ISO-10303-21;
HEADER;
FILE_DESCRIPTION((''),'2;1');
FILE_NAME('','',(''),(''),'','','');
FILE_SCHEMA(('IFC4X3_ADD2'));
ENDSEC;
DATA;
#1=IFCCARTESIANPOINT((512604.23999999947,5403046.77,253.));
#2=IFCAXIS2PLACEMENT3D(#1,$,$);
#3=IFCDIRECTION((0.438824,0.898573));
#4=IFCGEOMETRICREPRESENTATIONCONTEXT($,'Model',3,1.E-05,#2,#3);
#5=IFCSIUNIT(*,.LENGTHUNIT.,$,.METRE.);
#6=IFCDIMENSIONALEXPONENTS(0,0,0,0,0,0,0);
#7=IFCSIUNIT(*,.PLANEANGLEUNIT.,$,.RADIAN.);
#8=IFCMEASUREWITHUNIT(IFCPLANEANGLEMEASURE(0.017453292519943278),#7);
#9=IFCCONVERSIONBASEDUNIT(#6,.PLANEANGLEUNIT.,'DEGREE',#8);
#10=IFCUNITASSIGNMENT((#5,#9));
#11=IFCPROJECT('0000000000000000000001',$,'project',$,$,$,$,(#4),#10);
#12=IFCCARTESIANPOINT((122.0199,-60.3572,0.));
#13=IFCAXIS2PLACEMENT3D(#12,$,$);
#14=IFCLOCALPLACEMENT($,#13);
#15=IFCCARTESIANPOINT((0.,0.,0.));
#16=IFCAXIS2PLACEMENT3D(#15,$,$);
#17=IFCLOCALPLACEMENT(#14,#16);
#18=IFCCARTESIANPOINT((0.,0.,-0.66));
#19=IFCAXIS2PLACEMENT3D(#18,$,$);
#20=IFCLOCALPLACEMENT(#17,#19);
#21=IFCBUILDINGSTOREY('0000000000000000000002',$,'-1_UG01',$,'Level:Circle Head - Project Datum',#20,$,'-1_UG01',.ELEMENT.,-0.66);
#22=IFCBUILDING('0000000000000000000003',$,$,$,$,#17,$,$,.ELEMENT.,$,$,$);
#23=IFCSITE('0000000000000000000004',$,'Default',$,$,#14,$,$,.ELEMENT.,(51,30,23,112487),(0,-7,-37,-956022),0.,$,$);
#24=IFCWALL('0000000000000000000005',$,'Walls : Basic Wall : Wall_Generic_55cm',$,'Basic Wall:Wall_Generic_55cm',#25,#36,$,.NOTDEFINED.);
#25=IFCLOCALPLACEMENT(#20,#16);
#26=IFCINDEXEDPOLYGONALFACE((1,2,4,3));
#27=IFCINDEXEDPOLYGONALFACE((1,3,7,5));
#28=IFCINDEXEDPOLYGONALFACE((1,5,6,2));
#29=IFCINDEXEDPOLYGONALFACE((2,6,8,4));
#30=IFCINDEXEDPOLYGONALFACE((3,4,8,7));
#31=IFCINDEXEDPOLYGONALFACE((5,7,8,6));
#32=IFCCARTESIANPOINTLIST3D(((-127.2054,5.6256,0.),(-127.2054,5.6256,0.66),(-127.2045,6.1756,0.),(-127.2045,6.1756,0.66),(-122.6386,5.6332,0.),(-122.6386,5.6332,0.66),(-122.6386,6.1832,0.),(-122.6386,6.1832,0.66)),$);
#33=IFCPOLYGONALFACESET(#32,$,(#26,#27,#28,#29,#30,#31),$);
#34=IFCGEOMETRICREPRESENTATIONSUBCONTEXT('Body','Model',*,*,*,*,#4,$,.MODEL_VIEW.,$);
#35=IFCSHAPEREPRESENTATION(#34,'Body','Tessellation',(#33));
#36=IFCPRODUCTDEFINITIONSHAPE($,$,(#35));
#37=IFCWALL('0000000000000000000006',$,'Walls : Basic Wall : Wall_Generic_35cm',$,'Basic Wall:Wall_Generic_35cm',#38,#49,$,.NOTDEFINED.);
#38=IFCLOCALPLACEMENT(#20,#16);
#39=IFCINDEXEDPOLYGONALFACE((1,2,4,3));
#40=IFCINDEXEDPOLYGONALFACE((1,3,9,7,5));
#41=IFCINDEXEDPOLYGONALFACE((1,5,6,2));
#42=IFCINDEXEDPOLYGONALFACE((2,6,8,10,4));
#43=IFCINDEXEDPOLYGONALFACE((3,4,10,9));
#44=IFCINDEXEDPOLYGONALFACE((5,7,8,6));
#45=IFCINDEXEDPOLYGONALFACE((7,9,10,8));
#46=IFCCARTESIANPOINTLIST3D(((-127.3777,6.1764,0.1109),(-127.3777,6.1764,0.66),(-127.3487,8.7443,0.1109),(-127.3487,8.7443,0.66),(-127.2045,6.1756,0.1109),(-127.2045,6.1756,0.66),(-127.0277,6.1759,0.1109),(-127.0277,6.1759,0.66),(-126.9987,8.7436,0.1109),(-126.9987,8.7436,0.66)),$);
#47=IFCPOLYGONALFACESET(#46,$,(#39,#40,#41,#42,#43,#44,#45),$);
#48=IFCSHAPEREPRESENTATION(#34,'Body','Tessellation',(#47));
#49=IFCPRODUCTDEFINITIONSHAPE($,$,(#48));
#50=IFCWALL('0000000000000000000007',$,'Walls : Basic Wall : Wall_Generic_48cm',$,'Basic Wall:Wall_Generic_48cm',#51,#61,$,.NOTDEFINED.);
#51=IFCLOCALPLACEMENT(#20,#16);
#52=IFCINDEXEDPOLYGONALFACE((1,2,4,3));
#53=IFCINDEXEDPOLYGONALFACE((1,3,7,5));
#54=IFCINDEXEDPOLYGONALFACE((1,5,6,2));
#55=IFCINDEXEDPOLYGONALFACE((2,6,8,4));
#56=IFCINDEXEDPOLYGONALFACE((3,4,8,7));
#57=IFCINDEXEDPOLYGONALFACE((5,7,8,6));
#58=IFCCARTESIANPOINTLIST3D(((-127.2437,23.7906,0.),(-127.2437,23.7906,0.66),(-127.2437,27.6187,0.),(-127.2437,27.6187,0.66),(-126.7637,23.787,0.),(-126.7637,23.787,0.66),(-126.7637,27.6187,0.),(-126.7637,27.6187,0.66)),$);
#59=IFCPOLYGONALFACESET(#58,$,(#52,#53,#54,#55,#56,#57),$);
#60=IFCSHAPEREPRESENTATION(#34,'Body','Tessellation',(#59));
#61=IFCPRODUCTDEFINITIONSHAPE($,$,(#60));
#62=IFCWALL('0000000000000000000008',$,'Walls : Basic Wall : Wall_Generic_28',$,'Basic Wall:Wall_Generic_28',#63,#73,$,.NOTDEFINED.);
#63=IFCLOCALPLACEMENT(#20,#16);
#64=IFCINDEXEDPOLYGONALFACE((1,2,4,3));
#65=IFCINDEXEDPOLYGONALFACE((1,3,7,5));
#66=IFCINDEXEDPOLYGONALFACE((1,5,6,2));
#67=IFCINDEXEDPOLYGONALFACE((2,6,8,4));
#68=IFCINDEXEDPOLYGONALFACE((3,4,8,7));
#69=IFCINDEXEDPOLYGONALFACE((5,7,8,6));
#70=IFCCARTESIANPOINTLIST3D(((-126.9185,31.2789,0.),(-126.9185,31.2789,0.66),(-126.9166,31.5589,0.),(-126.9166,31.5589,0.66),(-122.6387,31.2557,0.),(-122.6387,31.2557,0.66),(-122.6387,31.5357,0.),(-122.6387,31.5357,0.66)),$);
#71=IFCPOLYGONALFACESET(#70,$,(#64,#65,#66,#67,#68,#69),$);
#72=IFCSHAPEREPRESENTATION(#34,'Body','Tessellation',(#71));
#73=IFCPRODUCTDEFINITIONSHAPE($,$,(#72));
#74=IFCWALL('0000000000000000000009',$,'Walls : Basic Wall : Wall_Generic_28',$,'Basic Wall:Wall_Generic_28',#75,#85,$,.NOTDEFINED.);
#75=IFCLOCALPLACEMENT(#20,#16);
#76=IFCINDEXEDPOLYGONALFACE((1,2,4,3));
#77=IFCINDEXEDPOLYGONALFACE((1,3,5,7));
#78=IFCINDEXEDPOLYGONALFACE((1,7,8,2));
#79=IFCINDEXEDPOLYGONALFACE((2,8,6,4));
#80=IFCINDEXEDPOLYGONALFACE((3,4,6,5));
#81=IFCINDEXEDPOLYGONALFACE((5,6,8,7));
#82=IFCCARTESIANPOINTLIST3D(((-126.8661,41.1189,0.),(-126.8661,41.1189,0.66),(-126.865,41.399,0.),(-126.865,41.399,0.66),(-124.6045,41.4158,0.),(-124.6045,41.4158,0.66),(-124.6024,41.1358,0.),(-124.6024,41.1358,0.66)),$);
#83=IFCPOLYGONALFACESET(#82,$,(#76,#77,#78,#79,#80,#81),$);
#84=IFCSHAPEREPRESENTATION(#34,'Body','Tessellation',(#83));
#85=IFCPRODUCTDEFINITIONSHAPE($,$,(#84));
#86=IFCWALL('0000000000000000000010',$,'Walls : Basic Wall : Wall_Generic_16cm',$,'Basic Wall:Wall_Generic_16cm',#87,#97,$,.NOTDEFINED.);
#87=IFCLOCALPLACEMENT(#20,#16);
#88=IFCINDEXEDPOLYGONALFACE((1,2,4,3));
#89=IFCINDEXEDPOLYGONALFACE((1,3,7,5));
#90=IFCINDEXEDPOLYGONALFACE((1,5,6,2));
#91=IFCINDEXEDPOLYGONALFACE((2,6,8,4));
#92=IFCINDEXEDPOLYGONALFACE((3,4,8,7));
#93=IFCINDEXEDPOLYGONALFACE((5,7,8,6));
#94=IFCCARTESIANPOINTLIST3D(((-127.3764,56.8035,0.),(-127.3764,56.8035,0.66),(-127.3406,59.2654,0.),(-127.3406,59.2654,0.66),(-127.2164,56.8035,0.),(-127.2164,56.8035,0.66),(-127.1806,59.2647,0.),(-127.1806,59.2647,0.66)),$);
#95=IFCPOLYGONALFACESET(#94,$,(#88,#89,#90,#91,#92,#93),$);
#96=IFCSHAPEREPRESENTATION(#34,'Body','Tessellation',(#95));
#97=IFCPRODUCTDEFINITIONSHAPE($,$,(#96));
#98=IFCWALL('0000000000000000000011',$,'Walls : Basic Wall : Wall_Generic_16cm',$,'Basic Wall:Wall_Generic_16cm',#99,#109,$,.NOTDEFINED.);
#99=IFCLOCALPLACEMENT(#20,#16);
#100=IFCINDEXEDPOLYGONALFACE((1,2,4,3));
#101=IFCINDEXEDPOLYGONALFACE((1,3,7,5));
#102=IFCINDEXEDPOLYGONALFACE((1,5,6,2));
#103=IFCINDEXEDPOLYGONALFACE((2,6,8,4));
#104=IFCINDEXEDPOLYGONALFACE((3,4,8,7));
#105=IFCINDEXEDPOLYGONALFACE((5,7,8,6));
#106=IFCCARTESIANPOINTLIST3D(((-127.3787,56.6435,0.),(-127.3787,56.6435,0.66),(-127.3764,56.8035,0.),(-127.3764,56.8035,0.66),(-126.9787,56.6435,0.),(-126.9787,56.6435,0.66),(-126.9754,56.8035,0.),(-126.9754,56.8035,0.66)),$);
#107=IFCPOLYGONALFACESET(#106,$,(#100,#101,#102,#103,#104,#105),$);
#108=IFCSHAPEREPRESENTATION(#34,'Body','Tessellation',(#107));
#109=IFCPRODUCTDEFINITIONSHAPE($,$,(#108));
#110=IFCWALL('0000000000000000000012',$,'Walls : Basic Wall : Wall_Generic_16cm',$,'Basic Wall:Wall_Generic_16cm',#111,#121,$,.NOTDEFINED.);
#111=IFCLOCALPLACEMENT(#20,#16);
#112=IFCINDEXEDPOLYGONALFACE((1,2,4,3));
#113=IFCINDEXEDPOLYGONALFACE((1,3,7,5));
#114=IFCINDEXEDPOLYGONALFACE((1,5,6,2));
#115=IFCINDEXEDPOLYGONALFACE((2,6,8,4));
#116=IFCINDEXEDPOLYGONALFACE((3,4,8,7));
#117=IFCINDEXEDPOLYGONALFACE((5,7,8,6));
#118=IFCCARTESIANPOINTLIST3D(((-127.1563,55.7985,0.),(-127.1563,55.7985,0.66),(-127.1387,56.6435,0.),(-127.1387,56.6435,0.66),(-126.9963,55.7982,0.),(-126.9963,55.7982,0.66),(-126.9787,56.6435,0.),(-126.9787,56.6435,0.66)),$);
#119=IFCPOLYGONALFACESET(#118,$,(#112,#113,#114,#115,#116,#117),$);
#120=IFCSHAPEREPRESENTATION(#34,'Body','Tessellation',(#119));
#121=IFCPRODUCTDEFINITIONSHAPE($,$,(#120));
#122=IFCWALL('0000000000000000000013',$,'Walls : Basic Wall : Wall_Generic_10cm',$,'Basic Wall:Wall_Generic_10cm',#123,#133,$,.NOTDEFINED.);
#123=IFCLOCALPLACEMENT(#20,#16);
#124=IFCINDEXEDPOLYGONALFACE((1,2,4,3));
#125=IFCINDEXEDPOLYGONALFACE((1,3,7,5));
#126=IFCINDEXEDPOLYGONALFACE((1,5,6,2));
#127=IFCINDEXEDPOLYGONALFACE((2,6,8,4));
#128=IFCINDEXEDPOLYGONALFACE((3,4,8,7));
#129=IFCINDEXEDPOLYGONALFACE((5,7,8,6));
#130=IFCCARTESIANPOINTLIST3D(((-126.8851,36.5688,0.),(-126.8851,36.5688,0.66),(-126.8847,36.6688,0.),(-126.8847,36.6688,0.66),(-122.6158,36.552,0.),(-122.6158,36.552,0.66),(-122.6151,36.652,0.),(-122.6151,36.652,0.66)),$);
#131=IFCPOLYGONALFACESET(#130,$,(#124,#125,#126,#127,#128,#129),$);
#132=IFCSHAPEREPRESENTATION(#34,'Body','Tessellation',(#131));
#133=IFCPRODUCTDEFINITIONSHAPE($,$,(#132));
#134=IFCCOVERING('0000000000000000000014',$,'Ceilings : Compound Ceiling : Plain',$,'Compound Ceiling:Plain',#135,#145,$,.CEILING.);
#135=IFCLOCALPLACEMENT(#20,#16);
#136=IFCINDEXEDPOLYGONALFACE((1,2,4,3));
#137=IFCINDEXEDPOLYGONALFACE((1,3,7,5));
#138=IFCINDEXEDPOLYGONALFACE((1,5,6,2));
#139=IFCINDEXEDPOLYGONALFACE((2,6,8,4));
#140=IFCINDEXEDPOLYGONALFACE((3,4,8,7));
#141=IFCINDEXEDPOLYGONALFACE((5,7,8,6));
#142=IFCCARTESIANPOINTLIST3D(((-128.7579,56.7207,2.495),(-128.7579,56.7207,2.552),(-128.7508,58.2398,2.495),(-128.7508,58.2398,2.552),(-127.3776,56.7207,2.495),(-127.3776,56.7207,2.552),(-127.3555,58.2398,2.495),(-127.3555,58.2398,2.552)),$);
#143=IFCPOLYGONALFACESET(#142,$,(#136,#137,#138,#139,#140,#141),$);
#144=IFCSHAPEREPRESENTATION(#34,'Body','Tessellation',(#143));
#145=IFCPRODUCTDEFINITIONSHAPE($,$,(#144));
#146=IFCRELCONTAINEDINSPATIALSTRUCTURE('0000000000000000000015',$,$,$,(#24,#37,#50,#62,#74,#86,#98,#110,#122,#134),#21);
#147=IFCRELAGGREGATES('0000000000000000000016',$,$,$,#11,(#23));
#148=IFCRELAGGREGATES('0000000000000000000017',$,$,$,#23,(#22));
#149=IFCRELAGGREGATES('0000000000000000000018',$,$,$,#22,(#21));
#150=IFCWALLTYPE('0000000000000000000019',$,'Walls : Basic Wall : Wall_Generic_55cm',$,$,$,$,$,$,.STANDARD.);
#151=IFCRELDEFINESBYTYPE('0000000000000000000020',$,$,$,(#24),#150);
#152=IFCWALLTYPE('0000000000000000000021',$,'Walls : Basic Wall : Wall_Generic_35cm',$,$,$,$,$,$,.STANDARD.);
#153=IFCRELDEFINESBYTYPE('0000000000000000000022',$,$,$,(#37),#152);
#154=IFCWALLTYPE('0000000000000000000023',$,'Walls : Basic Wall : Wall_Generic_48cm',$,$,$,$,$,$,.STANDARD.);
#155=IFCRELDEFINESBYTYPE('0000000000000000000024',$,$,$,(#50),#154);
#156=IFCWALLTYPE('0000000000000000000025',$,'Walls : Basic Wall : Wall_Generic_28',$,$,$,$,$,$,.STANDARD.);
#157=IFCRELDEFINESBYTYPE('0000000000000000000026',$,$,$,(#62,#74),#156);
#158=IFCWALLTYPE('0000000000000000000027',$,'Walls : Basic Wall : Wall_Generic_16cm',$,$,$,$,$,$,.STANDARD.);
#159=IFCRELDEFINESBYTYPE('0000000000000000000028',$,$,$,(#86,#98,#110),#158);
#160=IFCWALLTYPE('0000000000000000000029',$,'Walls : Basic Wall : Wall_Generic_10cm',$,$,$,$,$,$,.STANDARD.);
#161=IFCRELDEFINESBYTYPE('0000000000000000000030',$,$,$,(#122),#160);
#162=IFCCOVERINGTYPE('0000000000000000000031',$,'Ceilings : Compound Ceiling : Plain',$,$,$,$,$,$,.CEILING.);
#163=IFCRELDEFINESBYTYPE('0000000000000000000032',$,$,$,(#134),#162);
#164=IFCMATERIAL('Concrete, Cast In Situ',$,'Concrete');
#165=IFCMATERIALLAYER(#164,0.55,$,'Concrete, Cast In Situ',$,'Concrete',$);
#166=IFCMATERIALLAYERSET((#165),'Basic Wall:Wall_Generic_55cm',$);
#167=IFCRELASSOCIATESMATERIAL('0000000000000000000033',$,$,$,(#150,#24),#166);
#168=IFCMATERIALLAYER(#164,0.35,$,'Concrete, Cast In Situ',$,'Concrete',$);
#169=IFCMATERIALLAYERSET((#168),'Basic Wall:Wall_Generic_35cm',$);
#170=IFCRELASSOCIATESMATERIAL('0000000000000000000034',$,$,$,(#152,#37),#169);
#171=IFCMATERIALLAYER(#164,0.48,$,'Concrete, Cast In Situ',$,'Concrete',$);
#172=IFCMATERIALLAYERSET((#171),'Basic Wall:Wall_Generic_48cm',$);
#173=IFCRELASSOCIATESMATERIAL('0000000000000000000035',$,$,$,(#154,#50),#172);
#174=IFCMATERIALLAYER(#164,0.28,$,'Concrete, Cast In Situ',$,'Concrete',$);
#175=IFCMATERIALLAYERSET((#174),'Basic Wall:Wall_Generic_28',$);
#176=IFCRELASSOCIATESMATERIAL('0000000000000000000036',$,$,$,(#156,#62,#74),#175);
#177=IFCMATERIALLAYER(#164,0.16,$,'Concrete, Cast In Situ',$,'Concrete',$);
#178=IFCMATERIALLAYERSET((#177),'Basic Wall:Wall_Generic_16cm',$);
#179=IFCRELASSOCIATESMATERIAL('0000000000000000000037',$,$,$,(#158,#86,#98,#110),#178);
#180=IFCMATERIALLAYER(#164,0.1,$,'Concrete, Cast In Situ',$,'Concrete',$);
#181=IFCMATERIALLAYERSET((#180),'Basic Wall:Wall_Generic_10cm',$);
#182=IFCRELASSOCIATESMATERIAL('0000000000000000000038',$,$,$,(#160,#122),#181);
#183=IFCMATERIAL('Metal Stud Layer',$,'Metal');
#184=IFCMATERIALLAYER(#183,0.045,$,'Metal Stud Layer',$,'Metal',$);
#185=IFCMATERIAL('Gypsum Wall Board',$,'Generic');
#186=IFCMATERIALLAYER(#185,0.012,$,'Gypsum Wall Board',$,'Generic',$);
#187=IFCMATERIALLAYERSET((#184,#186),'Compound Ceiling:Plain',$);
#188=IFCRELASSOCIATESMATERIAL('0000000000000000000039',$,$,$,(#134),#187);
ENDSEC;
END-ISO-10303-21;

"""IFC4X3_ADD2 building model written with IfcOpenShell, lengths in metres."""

from ifc_helpers import new_model, entity, si_unit, converted_unit, direction, frame, origin, place, context, subcontext, project, spatial, polyline, outline, extrude, clip, halfspace, material, layer, layer_set, layer_usage, type_object, element, save


model = new_model("IFC4X3_ADD2")

# Units and contexts
model_context = context("Model", 3, precision=1e-05, world=frame((512604.23999999947, 5403046.77, 253.0)), true_north=direction((0.438824, 0.898573)))
body_context = subcontext(model_context, "Body", "Model", "MODEL_VIEW")
ifc_project = project(units=[si_unit("LENGTHUNIT", "METRE"), converted_unit("PLANEANGLEUNIT", "DEGREE", entity("IfcPlaneAngleMeasure", 0.017453292519943278), si_unit("PLANEANGLEUNIT", "RADIAN"), dimensions=[0, 0, 0, 0, 0, 0, 0])], contexts=[model_context])

# Site, building, storey
site_placement = place(None, frame((122.0199, -60.3572, 0.0)))
site = spatial("IfcSite", under=ifc_project, at=site_placement, Name="Default", CompositionType="ELEMENT", RefLatitude=(51, 30, 23, 112487), RefLongitude=(0, -7, -37, -956022), RefElevation=0.0)
building_placement = place(site_placement, origin())
building = spatial("IfcBuilding", under=site, at=building_placement, CompositionType="ELEMENT")
storey_placement = place(building_placement, frame((0.0, 0.0, -0.66)))
storey = spatial("IfcBuildingStorey", under=building, at=storey_placement, Name="-1_UG01", ObjectType="Level:Circle Head - Project Datum", LongName="-1_UG01", CompositionType="ELEMENT", Elevation=-0.66)

# Walls
ifc_material_1 = material(Name="Concrete, Cast In Situ", Category="Concrete")
ifc_layer_1 = layer(ifc_material_1, 0.55, Name="Concrete, Cast In Situ", Category="Concrete")
ifc_layer_set_1 = layer_set([ifc_layer_1], Name="Basic Wall:Wall_Generic_55cm")
wall_type_1 = type_object("IfcWallType", Name="Walls : Basic Wall : Wall_Generic_55cm", PredefinedType="STANDARD", material=ifc_layer_set_1)
wall_1_placement = place(storey_placement, frame((-127.2058, 5.9006, 0.0), z_axis=(0.0, 0.0, 1.0), x_axis=(0.999999, 0.001649, 0.0)))
element("IfcWall", 1, at=wall_1_placement, inside=storey, type_object=wall_type_1, material=ifc_layer_set_1, Name="Walls : Basic Wall : Wall_Generic_55cm", ObjectType="Basic Wall:Wall_Generic_55cm", PredefinedType="NOTDEFINED", context=body_context, shape_type="Clipping", body=[
    clip(extrude(outline(polyline([(4.5668, -0.275), (4.5677, 0.275), (0.0017, 0.275), (0.0, -0.275), (4.5668, -0.275)])), origin(), (0.0, 0.0, 1.0), 0.66), halfspace(origin(), True)),
])
ifc_layer_2 = layer(ifc_material_1, 0.35, Name="Concrete, Cast In Situ", Category="Concrete")
ifc_layer_set_2 = layer_set([ifc_layer_2], Name="Basic Wall:Wall_Generic_35cm")
wall_type_2 = type_object("IfcWallType", Name="Walls : Basic Wall : Wall_Generic_35cm", PredefinedType="STANDARD", material=ifc_layer_set_2)
wall_2_placement = place(storey_placement, frame((-127.1737, 8.7456, 0.1109), z_axis=(0.0, 0.0, 1.0), x_axis=(-0.011289, -0.999936, 0.0)))
element("IfcWall", 2, at=wall_2_placement, inside=storey, type_object=wall_type_2, material=ifc_layer_set_2, Name="Walls : Basic Wall : Wall_Generic_35cm", ObjectType="Basic Wall:Wall_Generic_35cm", PredefinedType="NOTDEFINED", context=body_context, shape_type="Clipping", body=[
    clip(extrude(outline(polyline([(2.5713, -0.175), (2.5701, -0.0018), (2.5678, 0.175), (0.0, 0.175), (0.0032, -0.175), (2.5713, -0.175)])), origin(), (0.0, 0.0, 1.0), 0.5491), halfspace(origin(), True)),
])
ifc_layer_3 = layer(ifc_material_1, 0.48, Name="Concrete, Cast In Situ", Category="Concrete")
ifc_layer_set_3 = layer_set([ifc_layer_3], Name="Basic Wall:Wall_Generic_48cm")
wall_type_3 = type_object("IfcWallType", Name="Walls : Basic Wall : Wall_Generic_48cm", PredefinedType="STANDARD", material=ifc_layer_set_3)
wall_3_placement = place(storey_placement, frame((-127.0037, 27.6187, 0.0), z_axis=(0.0, 0.0, 1.0), x_axis=(0.0, -1.0, 0.0)))
element("IfcWall", 3, at=wall_3_placement, inside=storey, type_object=wall_type_3, material=ifc_layer_set_3, Name="Walls : Basic Wall : Wall_Generic_48cm", ObjectType="Basic Wall:Wall_Generic_48cm", PredefinedType="NOTDEFINED", context=body_context, shape_type="Clipping", body=[
    clip(extrude(outline(polyline([(3.8282, -0.24), (3.8317, 0.2389), (3.8317, 0.24), (0.0, 0.24), (0.0, 0.11), (0.0, -0.24), (3.8282, -0.24)])), origin(), (0.0, 0.0, 1.0), 0.66), halfspace(origin(), True)),
])
ifc_layer_4 = layer(ifc_material_1, 0.28, Name="Concrete, Cast In Situ", Category="Concrete")
ifc_layer_set_4 = layer_set([ifc_layer_4], Name="Basic Wall:Wall_Generic_28")
wall_type_4 = type_object("IfcWallType", Name="Walls : Basic Wall : Wall_Generic_28", PredefinedType="STANDARD", material=ifc_layer_set_4)
wall_4_placement = place(storey_placement, frame((-126.9177, 31.4189, 0.0), z_axis=(0.0, 0.0, 1.0), x_axis=(0.999985, -0.005423, 0.0)))
element("IfcWall", 4, at=wall_4_placement, inside=storey, type_object=wall_type_4, material=ifc_layer_set_4, Name="Walls : Basic Wall : Wall_Generic_28", ObjectType="Basic Wall:Wall_Generic_28", PredefinedType="NOTDEFINED", context=body_context, shape_type="Clipping", body=[
    clip(extrude(outline(polyline([(4.2799, -0.14), (4.2783, 0.14), (2.2216, 0.14), (2.0816, 0.14), (0.0003, 0.14), (0.0, -0.14), (1.9244, -0.14), (1.9644, -0.14), (3.1331, -0.14), (3.2931, -0.14), (4.2799, -0.14)])), origin(), (0.0, 0.0, 1.0), 0.66), halfspace(origin(), True)),
])
wall_5_placement = place(storey_placement, frame((-126.8672, 41.2589, 0.0), z_axis=(0.0, 0.0, 1.0), x_axis=(0.999972, 0.007454, 0.0)))
element("IfcWall", 5, at=wall_5_placement, inside=storey, type_object=wall_type_4, material=ifc_layer_set_4, Name="Walls : Basic Wall : Wall_Generic_28", ObjectType="Basic Wall:Wall_Generic_28", PredefinedType="NOTDEFINED", context=body_context, shape_type="Clipping", body=[
    clip(extrude(outline(polyline([(2.2638, -0.14), (2.2638, 0.14), (0.0033, 0.14), (0.0, -0.14), (2.2638, -0.14)])), origin(), (0.0, 0.0, 1.0), 0.66), halfspace(origin(), True)),
])
ifc_layer_5 = layer(ifc_material_1, 0.16, Name="Concrete, Cast In Situ", Category="Concrete")
ifc_layer_set_5 = layer_set([ifc_layer_5], Name="Basic Wall:Wall_Generic_16cm")
wall_type_5 = type_object("IfcWallType", Name="Walls : Basic Wall : Wall_Generic_16cm", PredefinedType="STANDARD", material=ifc_layer_set_5)
wall_6_placement = place(storey_placement, frame((-127.2606, 59.2659, 0.0), z_axis=(0.0, 0.0, 1.0), x_axis=(-0.014531, -0.999894, 0.0)))
element("IfcWall", 6, at=wall_6_placement, inside=storey, type_object=wall_type_5, material=ifc_layer_set_5, Name="Walls : Basic Wall : Wall_Generic_16cm", ObjectType="Basic Wall:Wall_Generic_16cm", PredefinedType="NOTDEFINED", context=body_context, shape_type="Clipping", body=[
    clip(extrude(outline(polyline([(2.4638, -0.08), (2.4614, 0.08), (0.0, 0.08), (0.0016, -0.08), (0.9474, -0.08), (1.0274, -0.08), (2.4638, -0.08)])), origin(), (0.0, 0.0, 1.0), 0.66), halfspace(origin(), True)),
])
wall_7_placement = place(storey_placement, frame((-127.3787, 56.7235, 0.0)))
element("IfcWall", 7, at=wall_7_placement, inside=storey, type_object=wall_type_5, material=ifc_layer_set_5, Name="Walls : Basic Wall : Wall_Generic_16cm", ObjectType="Basic Wall:Wall_Generic_16cm", PredefinedType="NOTDEFINED", context=body_context, shape_type="Clipping", body=[
    clip(extrude(outline(polyline([(0.4, -0.08), (0.4034, 0.08), (0.1623, 0.08), (0.0023, 0.08), (0.0011, -0.0029), (0.0, -0.08), (0.24, -0.08), (0.4, -0.08)])), origin(), (0.0, 0.0, 1.0), 0.66), halfspace(origin(), True)),
])
wall_8_placement = place(storey_placement, frame((-127.0587, 56.6452, 0.0), z_axis=(0.0, 0.0, 1.0), x_axis=(-0.020814, -0.999783, 0.0)))
element("IfcWall", 8, at=wall_8_placement, inside=storey, type_object=wall_type_5, material=ifc_layer_set_5, Name="Walls : Basic Wall : Wall_Generic_16cm", ObjectType="Basic Wall:Wall_Generic_16cm", PredefinedType="NOTDEFINED", context=body_context, shape_type="Clipping", body=[
    clip(extrude(outline(polyline([(0.8485, -0.08), (0.8455, 0.08), (0.0, 0.08), (0.0033, -0.08), (0.8485, -0.08)])), origin(), (0.0, 0.0, 1.0), 0.66), halfspace(origin(), True)),
])
ifc_layer_6 = layer(ifc_material_1, 0.1, Name="Concrete, Cast In Situ", Category="Concrete")
ifc_layer_set_6 = layer_set([ifc_layer_6], Name="Basic Wall:Wall_Generic_10cm")
wall_type_6 = type_object("IfcWallType", Name="Walls : Basic Wall : Wall_Generic_10cm", PredefinedType="STANDARD", material=ifc_layer_set_6)
wall_9_placement = place(storey_placement, frame((-126.8849, 36.6188, 0.0), z_axis=(0.0, 0.0, 1.0), x_axis=(0.999992, -0.003937, 0.0)))
element("IfcWall", 9, at=wall_9_placement, inside=storey, type_object=wall_type_6, material=ifc_layer_set_6, Name="Walls : Basic Wall : Wall_Generic_10cm", ObjectType="Basic Wall:Wall_Generic_10cm", PredefinedType="NOTDEFINED", context=body_context, shape_type="Clipping", body=[
    clip(extrude(outline(polyline([(4.2694, -0.05), (4.2696, 0.05), (0.0, 0.05), (0.0, -0.05), (2.7103, -0.05), (2.8303, -0.05), (4.2694, -0.05)])), origin(), (0.0, 0.0, 1.0), 0.66), halfspace(origin(), True)),
])

# Covering
ifc_material_2 = material(Name="Metal Stud Layer", Category="Metal")
ifc_layer_7 = layer(ifc_material_2, 0.045, Name="Metal Stud Layer", Category="Metal")
ifc_material_3 = material(Name="Gypsum Wall Board", Category="Generic")
ifc_layer_8 = layer(ifc_material_3, 0.012, Name="Gypsum Wall Board", Category="Generic")
ifc_layer_set_7 = layer_set([ifc_layer_7, ifc_layer_8], Name="Compound Ceiling:Plain")
covering_type = type_object("IfcCoveringType", Name="Ceilings : Compound Ceiling : Plain", PredefinedType="CEILING")
ifc_layer_usage_1 = layer_usage(ifc_layer_set_7, "AXIS3", "NEGATIVE", 0.0)
covering_1_placement = place(storey_placement, frame((-128.7579, 56.7207, 2.495)))
element("IfcCovering", 10, at=covering_1_placement, inside=storey, type_object=covering_type, material=ifc_layer_usage_1, Name="Ceilings : Compound Ceiling : Plain", ObjectType="Compound Ceiling:Plain", PredefinedType="CEILING", context=body_context, shape_type="SweptSolid", body=[
    extrude(outline(polyline([(-0.7563, -0.6939), (0.7628, -0.6939), (0.7563, 0.6864), (-0.7629, 0.7014), (-0.7563, -0.6939)])), frame((0.6975, 0.7596, 0.0), z_axis=(0.0, 0.0, 1.0), x_axis=(-0.004694, -0.999989, 0.0)), (0.0, 0.0, 1.0), 0.057),
])

save(model, "model.ifc")
